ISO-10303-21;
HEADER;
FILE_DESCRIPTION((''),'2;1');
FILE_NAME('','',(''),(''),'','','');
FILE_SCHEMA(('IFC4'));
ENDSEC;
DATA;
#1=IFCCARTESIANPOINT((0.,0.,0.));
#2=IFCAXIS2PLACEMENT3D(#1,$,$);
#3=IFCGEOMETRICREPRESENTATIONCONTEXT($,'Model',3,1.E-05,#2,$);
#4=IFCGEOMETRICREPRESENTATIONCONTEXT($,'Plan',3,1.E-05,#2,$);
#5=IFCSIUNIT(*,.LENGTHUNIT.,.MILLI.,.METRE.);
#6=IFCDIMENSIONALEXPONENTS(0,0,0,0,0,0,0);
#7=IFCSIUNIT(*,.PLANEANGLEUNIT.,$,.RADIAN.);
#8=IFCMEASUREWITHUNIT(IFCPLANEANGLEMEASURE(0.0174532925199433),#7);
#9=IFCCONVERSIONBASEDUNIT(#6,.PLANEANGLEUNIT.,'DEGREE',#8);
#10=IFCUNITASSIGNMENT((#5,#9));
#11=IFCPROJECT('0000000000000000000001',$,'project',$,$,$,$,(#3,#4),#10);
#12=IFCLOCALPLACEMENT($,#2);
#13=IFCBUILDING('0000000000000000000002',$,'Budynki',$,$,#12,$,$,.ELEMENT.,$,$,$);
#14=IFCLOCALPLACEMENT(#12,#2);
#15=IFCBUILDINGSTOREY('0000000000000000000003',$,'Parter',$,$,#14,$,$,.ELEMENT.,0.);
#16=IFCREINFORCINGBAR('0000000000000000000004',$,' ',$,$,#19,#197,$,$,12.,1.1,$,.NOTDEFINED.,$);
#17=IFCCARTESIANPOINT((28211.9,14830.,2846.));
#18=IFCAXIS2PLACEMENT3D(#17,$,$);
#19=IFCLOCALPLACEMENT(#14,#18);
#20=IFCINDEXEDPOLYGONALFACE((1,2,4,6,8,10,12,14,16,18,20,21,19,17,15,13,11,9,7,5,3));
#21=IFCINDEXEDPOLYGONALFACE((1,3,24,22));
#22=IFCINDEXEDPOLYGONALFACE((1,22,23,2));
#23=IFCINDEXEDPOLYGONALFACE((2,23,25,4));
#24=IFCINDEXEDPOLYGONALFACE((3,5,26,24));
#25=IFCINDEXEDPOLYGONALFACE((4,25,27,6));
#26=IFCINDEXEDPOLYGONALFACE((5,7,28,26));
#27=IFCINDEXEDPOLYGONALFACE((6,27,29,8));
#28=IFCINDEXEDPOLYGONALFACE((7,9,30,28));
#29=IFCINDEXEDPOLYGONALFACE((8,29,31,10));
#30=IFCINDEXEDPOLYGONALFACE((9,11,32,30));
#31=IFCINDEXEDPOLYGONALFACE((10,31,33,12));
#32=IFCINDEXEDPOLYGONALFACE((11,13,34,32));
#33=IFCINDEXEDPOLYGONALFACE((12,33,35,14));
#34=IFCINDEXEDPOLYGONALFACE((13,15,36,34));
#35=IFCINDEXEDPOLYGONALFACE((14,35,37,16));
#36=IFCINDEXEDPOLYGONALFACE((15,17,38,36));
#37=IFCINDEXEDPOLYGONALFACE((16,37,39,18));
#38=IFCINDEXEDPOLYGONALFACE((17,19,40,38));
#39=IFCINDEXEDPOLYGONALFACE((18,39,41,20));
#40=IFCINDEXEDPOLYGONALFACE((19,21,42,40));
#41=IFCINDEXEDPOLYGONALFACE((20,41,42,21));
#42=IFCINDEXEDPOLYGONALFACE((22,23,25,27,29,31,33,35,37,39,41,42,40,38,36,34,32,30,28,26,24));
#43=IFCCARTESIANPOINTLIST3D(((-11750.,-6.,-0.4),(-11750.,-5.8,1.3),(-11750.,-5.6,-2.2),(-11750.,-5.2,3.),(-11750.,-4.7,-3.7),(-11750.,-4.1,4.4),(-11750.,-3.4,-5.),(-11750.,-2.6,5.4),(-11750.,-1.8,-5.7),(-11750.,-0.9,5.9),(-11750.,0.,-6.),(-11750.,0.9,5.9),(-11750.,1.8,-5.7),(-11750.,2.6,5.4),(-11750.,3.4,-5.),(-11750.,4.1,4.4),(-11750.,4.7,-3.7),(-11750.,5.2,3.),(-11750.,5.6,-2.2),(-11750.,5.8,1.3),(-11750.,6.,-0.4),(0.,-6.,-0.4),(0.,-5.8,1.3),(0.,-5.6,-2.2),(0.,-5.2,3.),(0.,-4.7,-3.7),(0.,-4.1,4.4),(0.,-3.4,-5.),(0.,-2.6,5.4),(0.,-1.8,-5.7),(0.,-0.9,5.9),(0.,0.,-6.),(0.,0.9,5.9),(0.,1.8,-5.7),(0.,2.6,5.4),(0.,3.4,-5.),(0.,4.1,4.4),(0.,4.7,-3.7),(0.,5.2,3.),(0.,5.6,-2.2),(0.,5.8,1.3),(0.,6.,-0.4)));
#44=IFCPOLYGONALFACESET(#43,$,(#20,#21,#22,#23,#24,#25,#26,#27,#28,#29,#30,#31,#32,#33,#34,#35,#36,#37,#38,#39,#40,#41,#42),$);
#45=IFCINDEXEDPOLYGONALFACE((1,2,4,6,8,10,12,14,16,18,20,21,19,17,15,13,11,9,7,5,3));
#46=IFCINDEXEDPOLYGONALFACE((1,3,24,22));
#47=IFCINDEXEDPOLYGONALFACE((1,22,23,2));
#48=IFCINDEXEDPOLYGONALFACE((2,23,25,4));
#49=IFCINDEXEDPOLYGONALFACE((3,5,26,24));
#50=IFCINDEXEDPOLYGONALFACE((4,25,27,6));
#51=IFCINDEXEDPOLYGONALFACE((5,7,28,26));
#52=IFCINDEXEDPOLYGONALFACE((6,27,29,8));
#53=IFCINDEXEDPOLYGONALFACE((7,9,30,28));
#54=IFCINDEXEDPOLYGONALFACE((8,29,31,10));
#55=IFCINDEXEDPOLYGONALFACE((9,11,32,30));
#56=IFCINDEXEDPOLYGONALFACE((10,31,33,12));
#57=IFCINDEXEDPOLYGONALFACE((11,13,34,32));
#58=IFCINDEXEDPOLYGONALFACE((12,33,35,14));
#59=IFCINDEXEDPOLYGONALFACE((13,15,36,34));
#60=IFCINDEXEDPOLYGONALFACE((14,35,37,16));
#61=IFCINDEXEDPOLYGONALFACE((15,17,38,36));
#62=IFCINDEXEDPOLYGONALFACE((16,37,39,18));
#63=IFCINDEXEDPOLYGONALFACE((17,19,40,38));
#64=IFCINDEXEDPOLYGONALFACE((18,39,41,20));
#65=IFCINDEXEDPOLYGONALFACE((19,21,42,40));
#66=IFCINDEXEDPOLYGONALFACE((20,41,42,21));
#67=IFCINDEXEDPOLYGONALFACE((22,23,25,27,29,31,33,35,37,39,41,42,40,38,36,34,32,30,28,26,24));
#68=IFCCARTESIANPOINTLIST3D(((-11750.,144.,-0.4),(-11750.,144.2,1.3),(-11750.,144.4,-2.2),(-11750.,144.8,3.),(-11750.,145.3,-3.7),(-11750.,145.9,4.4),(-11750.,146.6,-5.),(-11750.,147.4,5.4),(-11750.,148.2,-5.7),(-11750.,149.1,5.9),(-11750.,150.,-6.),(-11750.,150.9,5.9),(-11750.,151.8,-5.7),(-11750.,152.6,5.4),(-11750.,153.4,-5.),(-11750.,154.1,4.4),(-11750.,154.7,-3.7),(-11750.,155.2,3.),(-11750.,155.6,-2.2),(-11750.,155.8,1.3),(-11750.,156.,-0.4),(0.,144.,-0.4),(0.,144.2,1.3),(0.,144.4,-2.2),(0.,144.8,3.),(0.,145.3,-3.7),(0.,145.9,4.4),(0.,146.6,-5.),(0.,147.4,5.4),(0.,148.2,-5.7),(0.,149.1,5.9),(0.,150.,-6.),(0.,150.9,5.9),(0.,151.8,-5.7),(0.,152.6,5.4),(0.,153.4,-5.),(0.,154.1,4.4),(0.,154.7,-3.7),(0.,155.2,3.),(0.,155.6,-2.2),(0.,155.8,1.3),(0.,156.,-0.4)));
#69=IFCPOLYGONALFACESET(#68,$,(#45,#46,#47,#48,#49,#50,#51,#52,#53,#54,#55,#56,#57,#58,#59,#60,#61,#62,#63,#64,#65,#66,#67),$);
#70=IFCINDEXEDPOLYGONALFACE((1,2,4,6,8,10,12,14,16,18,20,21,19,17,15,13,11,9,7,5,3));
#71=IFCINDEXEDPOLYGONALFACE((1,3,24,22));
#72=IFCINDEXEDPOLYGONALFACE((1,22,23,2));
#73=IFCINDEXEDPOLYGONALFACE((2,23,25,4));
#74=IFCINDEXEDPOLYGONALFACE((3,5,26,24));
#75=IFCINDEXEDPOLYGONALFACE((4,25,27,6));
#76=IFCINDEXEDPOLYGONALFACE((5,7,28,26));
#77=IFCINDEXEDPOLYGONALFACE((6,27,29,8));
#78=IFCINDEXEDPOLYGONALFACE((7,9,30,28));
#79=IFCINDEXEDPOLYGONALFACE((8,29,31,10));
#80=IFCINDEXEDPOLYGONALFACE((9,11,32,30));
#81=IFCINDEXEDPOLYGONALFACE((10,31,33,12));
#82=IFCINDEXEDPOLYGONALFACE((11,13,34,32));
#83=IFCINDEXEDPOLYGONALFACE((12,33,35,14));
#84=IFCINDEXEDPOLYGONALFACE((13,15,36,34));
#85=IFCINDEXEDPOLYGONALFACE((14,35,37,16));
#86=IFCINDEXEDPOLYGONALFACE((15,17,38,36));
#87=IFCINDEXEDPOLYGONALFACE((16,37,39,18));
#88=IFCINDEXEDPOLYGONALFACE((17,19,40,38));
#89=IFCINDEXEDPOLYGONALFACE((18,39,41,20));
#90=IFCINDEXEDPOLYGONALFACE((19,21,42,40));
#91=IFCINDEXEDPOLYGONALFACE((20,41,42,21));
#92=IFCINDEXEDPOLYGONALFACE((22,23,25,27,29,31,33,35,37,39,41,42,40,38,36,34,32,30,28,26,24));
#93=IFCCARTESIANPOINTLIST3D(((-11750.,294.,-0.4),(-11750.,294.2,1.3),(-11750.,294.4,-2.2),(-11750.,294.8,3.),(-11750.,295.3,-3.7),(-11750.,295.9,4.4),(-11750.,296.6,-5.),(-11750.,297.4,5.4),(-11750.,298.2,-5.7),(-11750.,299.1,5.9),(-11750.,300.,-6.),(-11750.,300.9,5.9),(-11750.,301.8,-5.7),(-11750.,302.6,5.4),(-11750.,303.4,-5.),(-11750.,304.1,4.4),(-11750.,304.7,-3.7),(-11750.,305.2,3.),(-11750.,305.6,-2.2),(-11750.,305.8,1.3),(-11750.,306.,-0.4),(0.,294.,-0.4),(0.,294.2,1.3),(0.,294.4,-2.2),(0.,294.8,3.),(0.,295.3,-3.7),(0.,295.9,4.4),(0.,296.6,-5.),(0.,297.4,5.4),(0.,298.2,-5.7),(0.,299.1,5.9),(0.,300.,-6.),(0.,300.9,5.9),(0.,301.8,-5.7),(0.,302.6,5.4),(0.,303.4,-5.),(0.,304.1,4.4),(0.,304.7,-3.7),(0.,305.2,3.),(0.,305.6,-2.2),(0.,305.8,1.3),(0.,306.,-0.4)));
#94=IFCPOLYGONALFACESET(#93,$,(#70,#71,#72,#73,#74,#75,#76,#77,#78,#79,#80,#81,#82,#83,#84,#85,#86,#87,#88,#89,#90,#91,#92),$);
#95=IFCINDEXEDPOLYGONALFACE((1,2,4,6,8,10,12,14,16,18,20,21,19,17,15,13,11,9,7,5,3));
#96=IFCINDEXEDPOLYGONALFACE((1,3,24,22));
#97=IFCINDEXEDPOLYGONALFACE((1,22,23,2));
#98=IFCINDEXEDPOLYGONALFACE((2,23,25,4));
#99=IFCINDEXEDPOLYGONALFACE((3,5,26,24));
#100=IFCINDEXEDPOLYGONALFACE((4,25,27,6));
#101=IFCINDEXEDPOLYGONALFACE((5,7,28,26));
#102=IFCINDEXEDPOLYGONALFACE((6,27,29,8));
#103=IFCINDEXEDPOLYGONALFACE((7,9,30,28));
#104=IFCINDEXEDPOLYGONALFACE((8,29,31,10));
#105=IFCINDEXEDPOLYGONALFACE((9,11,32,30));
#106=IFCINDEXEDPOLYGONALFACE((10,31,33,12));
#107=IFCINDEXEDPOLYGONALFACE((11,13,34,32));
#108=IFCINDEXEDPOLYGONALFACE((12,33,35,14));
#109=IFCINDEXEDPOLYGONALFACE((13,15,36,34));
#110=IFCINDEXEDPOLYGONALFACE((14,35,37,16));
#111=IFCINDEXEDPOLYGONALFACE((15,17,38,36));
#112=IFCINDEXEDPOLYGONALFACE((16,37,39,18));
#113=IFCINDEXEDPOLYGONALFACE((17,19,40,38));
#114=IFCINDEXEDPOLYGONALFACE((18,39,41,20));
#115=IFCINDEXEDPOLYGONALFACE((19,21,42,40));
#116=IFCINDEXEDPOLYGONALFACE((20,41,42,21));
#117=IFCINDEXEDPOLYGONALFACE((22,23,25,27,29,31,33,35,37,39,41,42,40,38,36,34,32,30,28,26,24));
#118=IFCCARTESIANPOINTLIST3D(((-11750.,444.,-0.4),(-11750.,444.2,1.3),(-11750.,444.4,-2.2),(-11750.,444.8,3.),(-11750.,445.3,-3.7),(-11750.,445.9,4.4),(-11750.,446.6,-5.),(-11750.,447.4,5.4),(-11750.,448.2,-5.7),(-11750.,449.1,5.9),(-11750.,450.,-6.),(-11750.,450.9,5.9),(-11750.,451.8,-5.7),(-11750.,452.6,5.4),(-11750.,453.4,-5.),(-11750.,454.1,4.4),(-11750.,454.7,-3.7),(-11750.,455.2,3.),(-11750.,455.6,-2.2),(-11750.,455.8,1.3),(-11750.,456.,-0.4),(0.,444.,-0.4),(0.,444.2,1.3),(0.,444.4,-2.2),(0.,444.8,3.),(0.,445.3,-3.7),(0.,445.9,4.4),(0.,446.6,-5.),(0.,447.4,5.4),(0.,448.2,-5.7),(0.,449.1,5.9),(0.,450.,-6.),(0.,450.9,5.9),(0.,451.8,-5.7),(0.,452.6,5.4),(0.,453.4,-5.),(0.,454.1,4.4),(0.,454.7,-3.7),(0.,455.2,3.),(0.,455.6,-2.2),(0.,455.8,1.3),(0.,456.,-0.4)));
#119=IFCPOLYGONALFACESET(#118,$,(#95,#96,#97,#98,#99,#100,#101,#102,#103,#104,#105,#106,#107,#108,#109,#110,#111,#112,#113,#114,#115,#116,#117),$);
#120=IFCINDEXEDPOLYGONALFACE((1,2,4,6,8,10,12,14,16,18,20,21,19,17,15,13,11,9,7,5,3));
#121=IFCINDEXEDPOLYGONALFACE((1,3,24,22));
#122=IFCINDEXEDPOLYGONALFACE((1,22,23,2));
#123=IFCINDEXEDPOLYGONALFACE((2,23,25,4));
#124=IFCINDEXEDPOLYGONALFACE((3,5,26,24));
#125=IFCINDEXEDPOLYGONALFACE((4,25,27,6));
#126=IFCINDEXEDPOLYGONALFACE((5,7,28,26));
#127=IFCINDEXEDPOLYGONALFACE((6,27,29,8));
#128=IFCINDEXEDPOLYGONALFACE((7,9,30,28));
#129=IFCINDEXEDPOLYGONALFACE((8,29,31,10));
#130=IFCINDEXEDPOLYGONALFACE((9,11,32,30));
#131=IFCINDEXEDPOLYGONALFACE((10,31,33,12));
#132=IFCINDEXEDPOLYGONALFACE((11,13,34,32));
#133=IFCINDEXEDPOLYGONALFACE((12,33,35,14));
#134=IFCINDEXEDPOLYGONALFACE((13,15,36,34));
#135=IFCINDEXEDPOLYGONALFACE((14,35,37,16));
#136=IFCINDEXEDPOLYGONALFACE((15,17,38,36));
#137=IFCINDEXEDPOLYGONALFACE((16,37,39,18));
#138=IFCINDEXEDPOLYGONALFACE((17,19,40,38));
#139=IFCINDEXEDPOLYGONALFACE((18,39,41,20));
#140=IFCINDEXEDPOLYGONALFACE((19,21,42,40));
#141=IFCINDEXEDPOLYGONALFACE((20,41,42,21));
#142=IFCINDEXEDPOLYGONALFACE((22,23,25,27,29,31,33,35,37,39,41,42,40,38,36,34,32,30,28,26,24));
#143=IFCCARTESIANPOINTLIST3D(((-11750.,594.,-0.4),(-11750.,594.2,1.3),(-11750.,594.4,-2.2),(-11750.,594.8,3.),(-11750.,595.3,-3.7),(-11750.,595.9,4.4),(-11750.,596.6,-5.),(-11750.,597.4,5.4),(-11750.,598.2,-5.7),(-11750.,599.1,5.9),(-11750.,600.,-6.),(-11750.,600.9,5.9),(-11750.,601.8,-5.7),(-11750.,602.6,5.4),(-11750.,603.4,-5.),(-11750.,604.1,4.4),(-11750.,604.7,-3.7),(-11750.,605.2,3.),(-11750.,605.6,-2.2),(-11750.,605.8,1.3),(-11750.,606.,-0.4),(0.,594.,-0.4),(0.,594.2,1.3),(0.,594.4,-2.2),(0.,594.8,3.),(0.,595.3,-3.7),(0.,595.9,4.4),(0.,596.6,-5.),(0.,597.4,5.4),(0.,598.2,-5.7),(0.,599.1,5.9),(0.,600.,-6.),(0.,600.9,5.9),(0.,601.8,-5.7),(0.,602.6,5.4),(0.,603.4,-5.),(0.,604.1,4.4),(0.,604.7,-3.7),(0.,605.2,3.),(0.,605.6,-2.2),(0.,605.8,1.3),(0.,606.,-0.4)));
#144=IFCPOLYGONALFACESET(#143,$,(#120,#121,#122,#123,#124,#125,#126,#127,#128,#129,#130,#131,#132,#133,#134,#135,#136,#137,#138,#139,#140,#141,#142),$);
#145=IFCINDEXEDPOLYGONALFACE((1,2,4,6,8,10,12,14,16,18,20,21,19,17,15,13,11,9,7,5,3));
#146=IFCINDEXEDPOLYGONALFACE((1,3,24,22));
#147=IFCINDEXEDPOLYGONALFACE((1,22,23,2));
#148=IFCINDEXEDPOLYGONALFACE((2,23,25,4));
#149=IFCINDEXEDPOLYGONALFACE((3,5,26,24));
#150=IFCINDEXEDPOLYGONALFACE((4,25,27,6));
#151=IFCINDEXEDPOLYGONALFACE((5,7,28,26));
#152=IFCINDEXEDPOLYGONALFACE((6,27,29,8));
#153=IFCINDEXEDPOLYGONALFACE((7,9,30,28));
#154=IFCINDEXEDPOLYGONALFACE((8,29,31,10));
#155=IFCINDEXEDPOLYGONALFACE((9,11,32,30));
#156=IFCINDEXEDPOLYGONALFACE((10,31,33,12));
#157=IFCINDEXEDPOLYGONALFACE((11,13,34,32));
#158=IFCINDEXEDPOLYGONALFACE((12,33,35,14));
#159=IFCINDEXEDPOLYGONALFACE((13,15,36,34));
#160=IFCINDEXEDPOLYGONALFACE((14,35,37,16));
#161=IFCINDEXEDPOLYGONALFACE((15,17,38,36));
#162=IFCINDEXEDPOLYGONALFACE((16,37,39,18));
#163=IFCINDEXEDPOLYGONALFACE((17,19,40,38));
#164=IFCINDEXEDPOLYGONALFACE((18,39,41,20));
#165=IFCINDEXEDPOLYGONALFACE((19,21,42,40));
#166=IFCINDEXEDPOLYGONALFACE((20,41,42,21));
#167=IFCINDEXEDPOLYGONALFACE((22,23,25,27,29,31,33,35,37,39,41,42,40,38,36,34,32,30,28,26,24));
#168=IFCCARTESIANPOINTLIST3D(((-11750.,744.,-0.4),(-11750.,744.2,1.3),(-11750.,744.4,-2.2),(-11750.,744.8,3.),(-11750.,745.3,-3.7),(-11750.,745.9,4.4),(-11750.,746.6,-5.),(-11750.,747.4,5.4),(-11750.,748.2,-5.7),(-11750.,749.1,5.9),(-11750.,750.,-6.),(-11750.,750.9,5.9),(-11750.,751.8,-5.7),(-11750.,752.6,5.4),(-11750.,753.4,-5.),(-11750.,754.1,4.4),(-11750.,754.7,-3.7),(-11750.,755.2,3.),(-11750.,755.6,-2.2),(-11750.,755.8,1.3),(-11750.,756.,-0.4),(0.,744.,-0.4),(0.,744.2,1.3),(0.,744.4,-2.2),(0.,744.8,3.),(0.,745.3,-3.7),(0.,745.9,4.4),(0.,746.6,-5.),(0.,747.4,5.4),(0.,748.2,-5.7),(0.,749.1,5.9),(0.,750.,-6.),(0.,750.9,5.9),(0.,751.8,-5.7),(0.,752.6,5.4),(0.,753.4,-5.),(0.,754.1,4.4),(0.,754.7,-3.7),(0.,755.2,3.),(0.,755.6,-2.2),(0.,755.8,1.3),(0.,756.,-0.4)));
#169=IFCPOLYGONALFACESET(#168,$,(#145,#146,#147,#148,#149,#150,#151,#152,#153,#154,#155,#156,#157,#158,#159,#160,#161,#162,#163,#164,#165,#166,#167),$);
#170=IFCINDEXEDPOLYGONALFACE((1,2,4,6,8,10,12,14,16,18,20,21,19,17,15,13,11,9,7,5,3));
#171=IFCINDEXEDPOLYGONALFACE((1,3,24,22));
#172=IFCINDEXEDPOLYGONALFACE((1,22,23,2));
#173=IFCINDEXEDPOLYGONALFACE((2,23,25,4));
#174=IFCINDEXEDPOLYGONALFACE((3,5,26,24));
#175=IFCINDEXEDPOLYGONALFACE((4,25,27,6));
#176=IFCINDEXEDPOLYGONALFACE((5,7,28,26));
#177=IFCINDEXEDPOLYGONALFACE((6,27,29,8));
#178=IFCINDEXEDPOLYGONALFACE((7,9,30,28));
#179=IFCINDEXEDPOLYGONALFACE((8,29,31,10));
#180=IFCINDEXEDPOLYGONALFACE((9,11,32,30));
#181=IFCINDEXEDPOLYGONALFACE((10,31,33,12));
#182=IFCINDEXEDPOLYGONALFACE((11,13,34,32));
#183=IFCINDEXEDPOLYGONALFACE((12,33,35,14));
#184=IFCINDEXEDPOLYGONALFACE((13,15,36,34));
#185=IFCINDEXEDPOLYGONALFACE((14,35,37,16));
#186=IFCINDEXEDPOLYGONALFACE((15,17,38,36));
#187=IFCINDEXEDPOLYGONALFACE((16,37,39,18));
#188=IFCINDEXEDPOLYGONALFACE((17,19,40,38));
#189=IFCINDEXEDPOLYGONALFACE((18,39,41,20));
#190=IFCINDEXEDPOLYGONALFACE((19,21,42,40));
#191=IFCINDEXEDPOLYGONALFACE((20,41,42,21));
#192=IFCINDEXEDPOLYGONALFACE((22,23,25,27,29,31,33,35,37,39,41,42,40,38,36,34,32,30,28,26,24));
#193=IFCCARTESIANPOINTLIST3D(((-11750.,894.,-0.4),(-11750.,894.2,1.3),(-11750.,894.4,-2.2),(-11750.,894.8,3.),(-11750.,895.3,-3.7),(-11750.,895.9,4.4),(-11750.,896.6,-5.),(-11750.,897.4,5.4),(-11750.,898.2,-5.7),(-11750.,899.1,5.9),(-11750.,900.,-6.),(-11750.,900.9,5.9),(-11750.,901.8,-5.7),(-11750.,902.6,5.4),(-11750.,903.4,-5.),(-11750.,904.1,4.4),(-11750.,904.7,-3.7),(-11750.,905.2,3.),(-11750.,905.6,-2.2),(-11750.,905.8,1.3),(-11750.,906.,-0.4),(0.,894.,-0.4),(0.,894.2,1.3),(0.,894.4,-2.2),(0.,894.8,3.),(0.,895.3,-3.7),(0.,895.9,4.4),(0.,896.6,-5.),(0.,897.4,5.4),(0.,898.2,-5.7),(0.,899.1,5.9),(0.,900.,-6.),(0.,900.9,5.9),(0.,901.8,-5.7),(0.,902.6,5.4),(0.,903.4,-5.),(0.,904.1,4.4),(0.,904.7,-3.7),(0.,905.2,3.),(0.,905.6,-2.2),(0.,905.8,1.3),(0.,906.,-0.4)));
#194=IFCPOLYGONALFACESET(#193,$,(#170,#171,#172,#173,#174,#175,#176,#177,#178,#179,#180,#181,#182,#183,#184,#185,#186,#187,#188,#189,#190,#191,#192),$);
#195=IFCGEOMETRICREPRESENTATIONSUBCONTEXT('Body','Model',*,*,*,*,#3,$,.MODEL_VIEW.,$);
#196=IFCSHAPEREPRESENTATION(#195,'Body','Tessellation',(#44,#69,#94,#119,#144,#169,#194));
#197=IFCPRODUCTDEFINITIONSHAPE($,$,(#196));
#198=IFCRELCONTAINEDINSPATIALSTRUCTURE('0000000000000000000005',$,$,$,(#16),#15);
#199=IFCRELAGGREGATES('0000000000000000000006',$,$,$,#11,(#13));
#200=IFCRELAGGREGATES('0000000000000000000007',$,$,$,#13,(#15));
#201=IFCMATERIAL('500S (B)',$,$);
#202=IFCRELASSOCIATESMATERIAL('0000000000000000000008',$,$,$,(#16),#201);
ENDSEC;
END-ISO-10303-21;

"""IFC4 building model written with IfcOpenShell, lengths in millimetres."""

from ifc_helpers import new_model, entity, si_unit, converted_unit, frame, origin, place, context, subcontext, project, spatial, material, element, save


model = new_model("IFC4")

# Units and contexts
model_context = context("Model", 3, precision=1e-05, world=origin())
plan_context = context("Plan", 3, precision=1e-05, world=origin())
body_context = subcontext(model_context, "Body", "Model", "MODEL_VIEW")
ifc_project = project(units=[si_unit("LENGTHUNIT", "METRE", prefix="MILLI"), converted_unit("PLANEANGLEUNIT", "DEGREE", entity("IfcPlaneAngleMeasure", 0.0174532925199433), si_unit("PLANEANGLEUNIT", "RADIAN"), dimensions=[0, 0, 0, 0, 0, 0, 0])], contexts=[model_context, plan_context])

# Building, storey
building_placement = place(None, origin())
building = spatial("IfcBuilding", under=ifc_project, at=building_placement, Name="Budynki", CompositionType="ELEMENT")
storey_placement = place(building_placement, origin())
storey = spatial("IfcBuildingStorey", under=building, at=storey_placement, Name="Parter", CompositionType="ELEMENT", Elevation=0.0)

# Reinforcing bar
ifc_material_1 = material(Name="500S (B)")
reinforcing_bar_1_placement = place(storey_placement, frame((28211.9, 14830.0, 2846.0)))
element("IfcReinforcingBar", 1, at=reinforcing_bar_1_placement, inside=storey, material=ifc_material_1, Name=" ", CrossSectionArea=1.1, NominalDiameter=12.0, PredefinedType="NOTDEFINED", context=body_context, shape_type="AdvancedSweptSolid", body=[
    entity("IfcSweptDiskSolid", entity("IfcPolyline", [entity("IfcCartesianPoint", [0.0, 0.0, 0.0]), entity("IfcCartesianPoint", [-11750.0, 0.0, 0.0])]), 6.0, None, 0.0, 1.0),
    entity("IfcSweptDiskSolid", entity("IfcPolyline", [entity("IfcCartesianPoint", [0.0, 150.0, 0.0]), entity("IfcCartesianPoint", [-11750.0, 150.0, 0.0])]), 6.0, None, 0.0, 1.0),
    entity("IfcSweptDiskSolid", entity("IfcPolyline", [entity("IfcCartesianPoint", [0.0, 300.0, 0.0]), entity("IfcCartesianPoint", [-11750.0, 300.0, 0.0])]), 6.0, None, 0.0, 1.0),
    entity("IfcSweptDiskSolid", entity("IfcPolyline", [entity("IfcCartesianPoint", [0.0, 450.0, 0.0]), entity("IfcCartesianPoint", [-11750.0, 450.0, 0.0])]), 6.0, None, 0.0, 1.0),
    entity("IfcSweptDiskSolid", entity("IfcPolyline", [entity("IfcCartesianPoint", [0.0, 600.0, 0.0]), entity("IfcCartesianPoint", [-11750.0, 600.0, 0.0])]), 6.0, None, 0.0, 1.0),
    entity("IfcSweptDiskSolid", entity("IfcPolyline", [entity("IfcCartesianPoint", [0.0, 750.0, 0.0]), entity("IfcCartesianPoint", [-11750.0, 750.0, 0.0])]), 6.0, None, 0.0, 1.0),
    entity("IfcSweptDiskSolid", entity("IfcPolyline", [entity("IfcCartesianPoint", [0.0, 900.0, 0.0]), entity("IfcCartesianPoint", [-11750.0, 900.0, 0.0])]), 6.0, None, 0.0, 1.0),
])

save(model, "model.ifc")
